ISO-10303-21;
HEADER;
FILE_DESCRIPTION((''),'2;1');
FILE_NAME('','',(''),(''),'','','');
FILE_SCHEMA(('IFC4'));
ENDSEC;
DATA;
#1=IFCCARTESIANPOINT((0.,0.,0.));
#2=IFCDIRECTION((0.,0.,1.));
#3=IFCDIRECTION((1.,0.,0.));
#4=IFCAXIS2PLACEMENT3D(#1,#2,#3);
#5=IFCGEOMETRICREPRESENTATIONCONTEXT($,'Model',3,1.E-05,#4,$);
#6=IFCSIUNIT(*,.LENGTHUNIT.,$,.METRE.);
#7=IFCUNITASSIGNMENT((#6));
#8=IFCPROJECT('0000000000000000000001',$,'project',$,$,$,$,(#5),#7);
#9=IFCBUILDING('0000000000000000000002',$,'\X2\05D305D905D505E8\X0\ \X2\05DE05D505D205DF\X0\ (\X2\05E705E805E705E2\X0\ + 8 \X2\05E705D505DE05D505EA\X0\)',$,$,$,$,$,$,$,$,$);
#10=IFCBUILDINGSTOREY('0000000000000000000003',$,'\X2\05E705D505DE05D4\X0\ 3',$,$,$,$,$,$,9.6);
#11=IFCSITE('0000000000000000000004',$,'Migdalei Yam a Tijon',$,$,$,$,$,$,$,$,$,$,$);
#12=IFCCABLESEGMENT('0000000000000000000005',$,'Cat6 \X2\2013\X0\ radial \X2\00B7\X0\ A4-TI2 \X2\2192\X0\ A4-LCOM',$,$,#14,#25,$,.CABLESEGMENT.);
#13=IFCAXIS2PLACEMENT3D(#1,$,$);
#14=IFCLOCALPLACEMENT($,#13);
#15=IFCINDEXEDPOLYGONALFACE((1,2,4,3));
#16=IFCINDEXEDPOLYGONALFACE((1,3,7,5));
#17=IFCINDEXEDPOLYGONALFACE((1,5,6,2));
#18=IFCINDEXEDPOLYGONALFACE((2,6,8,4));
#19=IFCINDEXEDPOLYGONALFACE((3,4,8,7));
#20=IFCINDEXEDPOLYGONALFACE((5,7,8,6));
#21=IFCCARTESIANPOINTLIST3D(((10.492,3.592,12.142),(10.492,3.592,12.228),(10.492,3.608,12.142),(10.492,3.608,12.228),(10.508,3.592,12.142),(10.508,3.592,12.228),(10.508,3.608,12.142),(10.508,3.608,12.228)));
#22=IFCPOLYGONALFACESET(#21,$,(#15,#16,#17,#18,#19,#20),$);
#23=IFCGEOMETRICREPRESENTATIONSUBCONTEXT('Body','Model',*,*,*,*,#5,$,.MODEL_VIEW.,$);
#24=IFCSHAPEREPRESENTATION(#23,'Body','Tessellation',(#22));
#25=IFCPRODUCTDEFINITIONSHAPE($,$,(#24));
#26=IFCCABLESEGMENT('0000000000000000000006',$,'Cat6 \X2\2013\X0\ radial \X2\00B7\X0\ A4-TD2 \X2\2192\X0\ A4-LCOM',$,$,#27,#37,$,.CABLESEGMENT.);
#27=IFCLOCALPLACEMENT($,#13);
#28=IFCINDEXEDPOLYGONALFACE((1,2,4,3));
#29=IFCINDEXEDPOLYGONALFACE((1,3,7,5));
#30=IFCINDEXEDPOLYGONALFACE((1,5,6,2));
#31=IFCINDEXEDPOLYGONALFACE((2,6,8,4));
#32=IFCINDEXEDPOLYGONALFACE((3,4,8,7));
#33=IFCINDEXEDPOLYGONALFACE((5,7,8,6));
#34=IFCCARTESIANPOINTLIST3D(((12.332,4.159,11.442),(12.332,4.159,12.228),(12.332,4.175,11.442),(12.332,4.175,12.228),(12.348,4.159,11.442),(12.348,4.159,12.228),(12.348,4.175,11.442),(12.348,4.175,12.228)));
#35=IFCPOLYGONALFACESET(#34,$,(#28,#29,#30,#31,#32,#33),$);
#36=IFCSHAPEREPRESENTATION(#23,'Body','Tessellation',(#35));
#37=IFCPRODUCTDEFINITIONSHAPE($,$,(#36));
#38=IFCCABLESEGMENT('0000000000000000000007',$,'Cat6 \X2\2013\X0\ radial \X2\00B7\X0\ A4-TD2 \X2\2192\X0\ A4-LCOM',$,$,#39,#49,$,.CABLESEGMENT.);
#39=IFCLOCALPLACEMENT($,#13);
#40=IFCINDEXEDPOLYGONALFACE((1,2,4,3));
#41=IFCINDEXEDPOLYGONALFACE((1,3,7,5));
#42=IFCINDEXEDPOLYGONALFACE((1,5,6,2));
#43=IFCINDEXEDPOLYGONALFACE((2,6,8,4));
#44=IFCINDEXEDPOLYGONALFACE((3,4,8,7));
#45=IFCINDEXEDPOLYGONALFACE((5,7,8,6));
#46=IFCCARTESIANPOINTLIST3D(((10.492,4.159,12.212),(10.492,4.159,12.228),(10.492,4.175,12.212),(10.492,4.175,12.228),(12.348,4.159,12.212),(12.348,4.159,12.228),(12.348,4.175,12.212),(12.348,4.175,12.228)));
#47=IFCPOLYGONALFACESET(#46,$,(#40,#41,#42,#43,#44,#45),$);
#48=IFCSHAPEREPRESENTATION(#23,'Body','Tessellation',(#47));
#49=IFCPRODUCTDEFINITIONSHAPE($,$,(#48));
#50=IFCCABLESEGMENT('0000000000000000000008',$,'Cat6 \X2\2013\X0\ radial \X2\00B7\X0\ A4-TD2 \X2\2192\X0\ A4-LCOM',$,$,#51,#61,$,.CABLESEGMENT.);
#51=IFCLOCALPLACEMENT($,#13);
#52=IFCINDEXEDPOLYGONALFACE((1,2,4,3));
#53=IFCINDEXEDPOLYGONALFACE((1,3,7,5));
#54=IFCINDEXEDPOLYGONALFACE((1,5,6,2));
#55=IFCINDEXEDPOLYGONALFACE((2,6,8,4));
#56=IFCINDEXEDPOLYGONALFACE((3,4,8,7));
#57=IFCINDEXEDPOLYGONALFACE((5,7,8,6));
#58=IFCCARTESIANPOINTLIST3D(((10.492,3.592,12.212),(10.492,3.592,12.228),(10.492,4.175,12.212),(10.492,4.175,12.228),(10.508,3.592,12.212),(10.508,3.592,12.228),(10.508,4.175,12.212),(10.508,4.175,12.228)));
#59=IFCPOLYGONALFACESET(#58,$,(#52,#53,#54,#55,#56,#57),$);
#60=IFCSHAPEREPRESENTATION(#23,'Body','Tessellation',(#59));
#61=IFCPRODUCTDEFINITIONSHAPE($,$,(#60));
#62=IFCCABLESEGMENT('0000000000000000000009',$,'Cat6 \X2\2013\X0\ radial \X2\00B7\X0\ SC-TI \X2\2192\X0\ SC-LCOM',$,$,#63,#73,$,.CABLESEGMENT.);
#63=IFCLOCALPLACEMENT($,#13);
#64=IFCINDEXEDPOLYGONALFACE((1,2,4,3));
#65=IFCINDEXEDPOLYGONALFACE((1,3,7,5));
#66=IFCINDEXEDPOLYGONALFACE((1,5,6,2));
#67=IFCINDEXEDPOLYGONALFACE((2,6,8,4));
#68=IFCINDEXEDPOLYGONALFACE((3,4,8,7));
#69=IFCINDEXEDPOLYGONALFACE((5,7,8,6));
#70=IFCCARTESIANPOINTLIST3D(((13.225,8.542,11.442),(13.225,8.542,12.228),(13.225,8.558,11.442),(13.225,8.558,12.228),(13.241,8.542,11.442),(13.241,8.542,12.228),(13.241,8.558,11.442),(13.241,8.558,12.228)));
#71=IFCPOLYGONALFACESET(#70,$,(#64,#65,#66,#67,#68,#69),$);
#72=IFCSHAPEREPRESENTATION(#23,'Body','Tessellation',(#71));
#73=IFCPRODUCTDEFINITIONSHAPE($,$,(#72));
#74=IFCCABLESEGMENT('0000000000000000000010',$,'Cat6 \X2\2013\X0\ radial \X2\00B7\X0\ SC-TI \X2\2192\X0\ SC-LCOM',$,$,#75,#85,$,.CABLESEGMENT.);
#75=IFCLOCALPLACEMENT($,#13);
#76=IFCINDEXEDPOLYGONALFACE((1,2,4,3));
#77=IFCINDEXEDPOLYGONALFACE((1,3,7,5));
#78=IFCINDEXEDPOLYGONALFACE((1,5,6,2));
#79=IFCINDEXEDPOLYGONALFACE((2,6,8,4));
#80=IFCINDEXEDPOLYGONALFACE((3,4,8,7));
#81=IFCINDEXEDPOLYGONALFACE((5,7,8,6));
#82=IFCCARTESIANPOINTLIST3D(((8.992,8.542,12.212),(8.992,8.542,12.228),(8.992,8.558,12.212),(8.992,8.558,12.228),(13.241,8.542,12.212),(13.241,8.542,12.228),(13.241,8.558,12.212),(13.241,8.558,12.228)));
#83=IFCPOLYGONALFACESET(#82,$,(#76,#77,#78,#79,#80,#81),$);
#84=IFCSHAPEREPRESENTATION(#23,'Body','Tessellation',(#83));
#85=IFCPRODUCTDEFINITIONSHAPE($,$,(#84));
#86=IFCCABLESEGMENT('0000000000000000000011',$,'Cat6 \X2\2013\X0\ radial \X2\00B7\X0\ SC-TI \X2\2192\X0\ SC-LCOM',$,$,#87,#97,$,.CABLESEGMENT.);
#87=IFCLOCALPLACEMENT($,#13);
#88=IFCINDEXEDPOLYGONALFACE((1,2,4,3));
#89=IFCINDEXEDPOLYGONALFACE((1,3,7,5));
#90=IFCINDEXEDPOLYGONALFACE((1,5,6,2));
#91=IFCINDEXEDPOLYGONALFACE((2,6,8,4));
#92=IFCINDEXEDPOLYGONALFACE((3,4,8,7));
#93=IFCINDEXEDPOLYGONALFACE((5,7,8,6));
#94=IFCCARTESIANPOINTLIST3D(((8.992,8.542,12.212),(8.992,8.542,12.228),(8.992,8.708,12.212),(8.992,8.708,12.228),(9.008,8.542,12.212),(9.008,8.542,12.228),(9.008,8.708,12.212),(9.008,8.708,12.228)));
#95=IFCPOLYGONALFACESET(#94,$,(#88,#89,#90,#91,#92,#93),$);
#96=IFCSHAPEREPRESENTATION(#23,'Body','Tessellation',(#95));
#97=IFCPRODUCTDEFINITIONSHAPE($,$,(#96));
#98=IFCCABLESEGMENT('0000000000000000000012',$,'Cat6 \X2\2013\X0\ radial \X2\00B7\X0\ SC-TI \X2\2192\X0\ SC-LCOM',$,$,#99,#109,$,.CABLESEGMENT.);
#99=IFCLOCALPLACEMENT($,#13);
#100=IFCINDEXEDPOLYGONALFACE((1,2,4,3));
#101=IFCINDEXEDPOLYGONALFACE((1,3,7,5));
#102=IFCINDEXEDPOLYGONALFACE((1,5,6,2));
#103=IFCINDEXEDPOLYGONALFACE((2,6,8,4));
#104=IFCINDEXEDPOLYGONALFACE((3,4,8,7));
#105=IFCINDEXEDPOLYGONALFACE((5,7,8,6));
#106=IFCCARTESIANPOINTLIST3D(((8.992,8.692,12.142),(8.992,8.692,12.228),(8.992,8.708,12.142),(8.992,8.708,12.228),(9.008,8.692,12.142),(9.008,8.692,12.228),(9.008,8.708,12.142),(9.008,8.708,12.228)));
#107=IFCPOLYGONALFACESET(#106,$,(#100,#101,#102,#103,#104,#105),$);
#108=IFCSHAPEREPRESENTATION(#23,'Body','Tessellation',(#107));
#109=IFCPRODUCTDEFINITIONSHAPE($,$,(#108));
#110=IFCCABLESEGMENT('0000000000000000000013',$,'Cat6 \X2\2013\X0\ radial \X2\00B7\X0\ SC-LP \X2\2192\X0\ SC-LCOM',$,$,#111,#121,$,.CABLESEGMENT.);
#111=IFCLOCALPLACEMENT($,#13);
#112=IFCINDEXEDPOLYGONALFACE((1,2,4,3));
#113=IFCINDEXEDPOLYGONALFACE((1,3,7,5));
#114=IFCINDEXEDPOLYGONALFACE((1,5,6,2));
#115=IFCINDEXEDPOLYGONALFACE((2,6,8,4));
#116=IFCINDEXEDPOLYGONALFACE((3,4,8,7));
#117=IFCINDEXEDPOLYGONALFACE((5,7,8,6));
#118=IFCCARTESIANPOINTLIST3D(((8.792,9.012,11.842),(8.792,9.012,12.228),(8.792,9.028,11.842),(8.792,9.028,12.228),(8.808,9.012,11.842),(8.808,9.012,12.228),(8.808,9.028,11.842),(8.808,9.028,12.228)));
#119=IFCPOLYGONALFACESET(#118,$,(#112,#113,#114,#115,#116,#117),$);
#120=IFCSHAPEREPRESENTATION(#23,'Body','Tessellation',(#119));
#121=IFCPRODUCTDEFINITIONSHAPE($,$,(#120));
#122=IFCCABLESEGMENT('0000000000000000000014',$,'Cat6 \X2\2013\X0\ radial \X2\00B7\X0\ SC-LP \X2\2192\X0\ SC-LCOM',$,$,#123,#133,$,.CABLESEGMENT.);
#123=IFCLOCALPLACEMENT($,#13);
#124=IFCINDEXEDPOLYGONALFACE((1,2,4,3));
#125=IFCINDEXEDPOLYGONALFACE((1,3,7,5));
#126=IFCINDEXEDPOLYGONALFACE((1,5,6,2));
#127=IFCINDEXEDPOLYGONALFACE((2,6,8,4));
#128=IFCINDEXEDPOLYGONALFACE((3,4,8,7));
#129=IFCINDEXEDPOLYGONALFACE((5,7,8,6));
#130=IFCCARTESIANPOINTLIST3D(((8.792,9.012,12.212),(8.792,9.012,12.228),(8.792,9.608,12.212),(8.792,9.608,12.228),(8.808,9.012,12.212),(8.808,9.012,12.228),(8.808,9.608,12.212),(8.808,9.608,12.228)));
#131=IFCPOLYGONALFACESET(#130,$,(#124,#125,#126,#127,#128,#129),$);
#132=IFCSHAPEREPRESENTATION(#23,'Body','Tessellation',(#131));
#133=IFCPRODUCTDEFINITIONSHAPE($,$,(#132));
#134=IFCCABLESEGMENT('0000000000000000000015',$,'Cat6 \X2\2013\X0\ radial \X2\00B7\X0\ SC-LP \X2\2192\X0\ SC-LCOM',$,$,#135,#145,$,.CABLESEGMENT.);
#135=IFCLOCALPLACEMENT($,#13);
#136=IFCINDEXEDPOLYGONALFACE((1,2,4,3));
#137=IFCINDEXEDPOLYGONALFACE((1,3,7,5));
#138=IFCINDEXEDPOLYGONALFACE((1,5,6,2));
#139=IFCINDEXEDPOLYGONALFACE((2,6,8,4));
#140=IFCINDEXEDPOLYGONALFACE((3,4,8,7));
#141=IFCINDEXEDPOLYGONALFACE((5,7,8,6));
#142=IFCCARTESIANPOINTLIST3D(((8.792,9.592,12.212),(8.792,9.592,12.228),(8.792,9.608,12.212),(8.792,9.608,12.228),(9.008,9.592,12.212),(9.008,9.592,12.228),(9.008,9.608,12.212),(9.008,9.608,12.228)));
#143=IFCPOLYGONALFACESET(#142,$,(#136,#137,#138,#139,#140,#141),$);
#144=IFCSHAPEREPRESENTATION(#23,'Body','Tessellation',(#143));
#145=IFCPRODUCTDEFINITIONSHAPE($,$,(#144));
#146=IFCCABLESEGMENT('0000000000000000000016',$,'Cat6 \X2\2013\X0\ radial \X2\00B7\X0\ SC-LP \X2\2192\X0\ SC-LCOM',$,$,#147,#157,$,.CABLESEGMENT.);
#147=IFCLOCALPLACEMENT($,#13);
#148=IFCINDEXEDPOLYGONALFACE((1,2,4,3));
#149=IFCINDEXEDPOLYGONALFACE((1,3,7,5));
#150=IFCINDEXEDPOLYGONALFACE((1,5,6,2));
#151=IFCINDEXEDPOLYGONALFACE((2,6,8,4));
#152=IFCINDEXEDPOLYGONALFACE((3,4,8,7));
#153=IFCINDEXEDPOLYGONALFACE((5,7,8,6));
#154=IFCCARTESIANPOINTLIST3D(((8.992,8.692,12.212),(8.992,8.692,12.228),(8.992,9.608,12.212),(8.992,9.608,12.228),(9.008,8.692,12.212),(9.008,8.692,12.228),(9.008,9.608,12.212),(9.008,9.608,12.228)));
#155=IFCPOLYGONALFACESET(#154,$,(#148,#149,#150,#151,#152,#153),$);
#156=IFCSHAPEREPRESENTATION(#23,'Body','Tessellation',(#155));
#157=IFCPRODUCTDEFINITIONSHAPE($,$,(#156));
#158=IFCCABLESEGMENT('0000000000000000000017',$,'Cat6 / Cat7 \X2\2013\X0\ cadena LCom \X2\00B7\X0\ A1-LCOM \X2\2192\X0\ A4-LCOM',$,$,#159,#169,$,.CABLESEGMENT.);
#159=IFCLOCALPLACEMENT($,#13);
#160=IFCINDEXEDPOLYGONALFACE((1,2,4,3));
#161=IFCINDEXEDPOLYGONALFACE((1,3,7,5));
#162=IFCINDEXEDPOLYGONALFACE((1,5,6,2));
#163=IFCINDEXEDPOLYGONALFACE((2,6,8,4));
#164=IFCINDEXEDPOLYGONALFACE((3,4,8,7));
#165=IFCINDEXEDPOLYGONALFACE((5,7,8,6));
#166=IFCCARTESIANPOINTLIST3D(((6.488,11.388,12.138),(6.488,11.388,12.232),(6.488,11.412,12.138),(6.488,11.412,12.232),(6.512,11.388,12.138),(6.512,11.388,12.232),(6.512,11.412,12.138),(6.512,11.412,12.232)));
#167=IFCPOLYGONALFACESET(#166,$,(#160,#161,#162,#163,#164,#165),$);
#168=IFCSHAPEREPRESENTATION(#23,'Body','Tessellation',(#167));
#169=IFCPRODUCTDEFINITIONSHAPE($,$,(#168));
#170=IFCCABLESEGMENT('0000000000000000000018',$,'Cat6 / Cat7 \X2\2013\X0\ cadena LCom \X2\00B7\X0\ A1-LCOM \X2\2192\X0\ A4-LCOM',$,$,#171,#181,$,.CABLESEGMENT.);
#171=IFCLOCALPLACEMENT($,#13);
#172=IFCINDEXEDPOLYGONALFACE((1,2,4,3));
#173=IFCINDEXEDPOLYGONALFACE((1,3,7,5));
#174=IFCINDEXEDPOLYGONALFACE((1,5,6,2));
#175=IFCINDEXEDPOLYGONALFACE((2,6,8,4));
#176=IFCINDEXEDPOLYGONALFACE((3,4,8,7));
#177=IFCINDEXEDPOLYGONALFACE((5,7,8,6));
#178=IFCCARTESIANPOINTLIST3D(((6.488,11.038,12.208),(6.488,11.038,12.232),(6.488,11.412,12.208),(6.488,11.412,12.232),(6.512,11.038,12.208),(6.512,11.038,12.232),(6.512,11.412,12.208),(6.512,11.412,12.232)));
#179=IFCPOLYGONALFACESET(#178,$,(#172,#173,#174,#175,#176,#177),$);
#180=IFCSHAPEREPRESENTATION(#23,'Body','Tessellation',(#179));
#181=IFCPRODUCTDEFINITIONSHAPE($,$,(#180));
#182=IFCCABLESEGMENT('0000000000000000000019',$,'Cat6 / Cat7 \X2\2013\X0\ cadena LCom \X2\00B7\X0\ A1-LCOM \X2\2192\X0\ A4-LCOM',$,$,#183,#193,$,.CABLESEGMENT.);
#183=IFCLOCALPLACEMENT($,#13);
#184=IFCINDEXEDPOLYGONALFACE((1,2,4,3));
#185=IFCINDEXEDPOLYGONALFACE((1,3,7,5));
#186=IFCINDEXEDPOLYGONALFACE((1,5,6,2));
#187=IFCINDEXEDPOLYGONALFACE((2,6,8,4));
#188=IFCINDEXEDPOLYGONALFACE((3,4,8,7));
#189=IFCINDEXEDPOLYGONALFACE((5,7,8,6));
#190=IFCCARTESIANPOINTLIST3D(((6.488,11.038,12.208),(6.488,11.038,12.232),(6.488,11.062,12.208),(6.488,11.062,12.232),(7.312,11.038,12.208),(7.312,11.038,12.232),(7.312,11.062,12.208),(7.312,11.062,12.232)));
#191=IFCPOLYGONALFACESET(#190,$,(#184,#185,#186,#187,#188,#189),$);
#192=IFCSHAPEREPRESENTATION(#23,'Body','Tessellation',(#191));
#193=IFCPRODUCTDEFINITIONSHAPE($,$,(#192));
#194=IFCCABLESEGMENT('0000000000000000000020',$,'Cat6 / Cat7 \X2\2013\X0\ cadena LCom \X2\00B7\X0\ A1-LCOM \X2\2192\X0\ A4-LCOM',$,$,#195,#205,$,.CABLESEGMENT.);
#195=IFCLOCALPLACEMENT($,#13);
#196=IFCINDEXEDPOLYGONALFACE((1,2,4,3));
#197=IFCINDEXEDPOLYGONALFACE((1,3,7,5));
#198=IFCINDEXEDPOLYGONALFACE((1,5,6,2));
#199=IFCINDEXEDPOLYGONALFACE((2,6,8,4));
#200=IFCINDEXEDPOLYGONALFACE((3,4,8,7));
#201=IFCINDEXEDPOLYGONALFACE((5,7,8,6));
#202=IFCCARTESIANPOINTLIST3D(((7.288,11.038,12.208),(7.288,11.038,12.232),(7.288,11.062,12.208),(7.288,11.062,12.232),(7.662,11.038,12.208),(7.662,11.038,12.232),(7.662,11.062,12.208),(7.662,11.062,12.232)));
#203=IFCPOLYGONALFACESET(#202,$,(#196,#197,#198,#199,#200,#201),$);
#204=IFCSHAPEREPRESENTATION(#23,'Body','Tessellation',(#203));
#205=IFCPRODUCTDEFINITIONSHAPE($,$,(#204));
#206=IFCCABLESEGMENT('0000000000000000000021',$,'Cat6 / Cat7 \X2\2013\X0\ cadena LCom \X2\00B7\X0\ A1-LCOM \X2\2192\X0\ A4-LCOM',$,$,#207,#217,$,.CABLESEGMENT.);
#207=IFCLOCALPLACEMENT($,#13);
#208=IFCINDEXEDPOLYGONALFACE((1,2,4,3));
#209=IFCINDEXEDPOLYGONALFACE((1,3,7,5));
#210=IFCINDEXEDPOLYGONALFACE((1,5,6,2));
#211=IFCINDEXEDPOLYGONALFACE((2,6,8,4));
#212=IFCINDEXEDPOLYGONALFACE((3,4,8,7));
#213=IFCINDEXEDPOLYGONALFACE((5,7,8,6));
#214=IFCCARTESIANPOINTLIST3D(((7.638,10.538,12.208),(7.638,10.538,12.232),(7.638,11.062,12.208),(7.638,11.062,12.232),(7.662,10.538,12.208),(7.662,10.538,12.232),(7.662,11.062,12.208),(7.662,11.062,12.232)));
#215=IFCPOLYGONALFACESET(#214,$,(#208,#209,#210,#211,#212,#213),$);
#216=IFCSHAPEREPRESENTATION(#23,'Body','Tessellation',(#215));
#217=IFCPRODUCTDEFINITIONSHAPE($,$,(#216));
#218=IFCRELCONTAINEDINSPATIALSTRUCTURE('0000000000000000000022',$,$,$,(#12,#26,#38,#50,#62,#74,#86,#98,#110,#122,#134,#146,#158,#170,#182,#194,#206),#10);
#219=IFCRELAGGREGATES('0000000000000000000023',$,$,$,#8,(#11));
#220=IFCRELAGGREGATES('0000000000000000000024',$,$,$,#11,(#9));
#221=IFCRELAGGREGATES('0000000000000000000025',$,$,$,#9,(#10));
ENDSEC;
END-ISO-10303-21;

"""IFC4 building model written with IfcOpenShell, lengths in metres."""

from ifc_helpers import new_model, si_unit, frame, origin_with_axes, context, subcontext, project, spatial, line, indexed_curve, outline, extrude, element, save


model = new_model("IFC4")

# Units and contexts
model_context = context("Model", 3, precision=1e-05, world=origin_with_axes())
body_context = subcontext(model_context, "Body", "Model", "MODEL_VIEW")
ifc_project = project(units=[si_unit("LENGTHUNIT", "METRE")], contexts=[model_context])

# Site, building, storey
site = spatial("IfcSite", under=ifc_project, Name="Migdalei Yam a Tijon")
building = spatial("IfcBuilding", under=site, Name="דיור מוגן (קרקע + 8 קומות)")
storey = spatial("IfcBuildingStorey", under=building, Name="קומה 3", Elevation=9.6)

# Cable segments
element("IfcCableSegment", 1, inside=storey, Name="Cat6 – radial · A4-TI2 → A4-LCOM", PredefinedType="CABLESEGMENT", context=body_context, shape_type="SweptSolid", body=[
    extrude(outline(indexed_curve([(0.0, 0.0), (0.016, 0.0), (0.016, 0.016), (0.0, 0.016)], segments=[line(1, 2, 3, 4, 1)])), frame((10.492, 3.592, 12.142), z_axis=(0.0, 0.0, 1.0), x_axis=(1.0, 0.0, 0.0)), (0.0, 0.0, 1.0), 0.086),
])
element("IfcCableSegment", 2, inside=storey, Name="Cat6 – radial · A4-TD2 → A4-LCOM", PredefinedType="CABLESEGMENT", context=body_context, shape_type="SweptSolid", body=[
    extrude(outline(indexed_curve([(0.0, 0.0), (0.016, 0.0), (0.016, 0.016), (0.0, 0.016)], segments=[line(1, 2, 3, 4, 1)])), frame((12.332, 4.159, 11.442), z_axis=(0.0, 0.0, 1.0), x_axis=(1.0, 0.0, 0.0)), (0.0, 0.0, 1.0), 0.786),
])
element("IfcCableSegment", 3, inside=storey, Name="Cat6 – radial · A4-TD2 → A4-LCOM", PredefinedType="CABLESEGMENT", context=body_context, shape_type="SweptSolid", body=[
    extrude(outline(indexed_curve([(0.0, 0.0), (1.856, 0.0), (1.856, 0.016), (0.0, 0.016)], segments=[line(1, 2, 3, 4, 1)])), frame((10.492, 4.159, 12.212), z_axis=(0.0, 0.0, 1.0), x_axis=(1.0, 0.0, 0.0)), (0.0, 0.0, 1.0), 0.016),
])
element("IfcCableSegment", 4, inside=storey, Name="Cat6 – radial · A4-TD2 → A4-LCOM", PredefinedType="CABLESEGMENT", context=body_context, shape_type="SweptSolid", body=[
    extrude(outline(indexed_curve([(0.0, 0.0), (0.016, 0.0), (0.016, 0.583), (0.0, 0.583)], segments=[line(1, 2, 3, 4, 1)])), frame((10.492, 3.592, 12.212), z_axis=(0.0, 0.0, 1.0), x_axis=(1.0, 0.0, 0.0)), (0.0, 0.0, 1.0), 0.016),
])
element("IfcCableSegment", 5, inside=storey, Name="Cat6 – radial · SC-TI → SC-LCOM", PredefinedType="CABLESEGMENT", context=body_context, shape_type="SweptSolid", body=[
    extrude(outline(indexed_curve([(0.0, 0.0), (0.016, 0.0), (0.016, 0.016), (0.0, 0.016)], segments=[line(1, 2, 3, 4, 1)])), frame((13.225, 8.542, 11.442), z_axis=(0.0, 0.0, 1.0), x_axis=(1.0, 0.0, 0.0)), (0.0, 0.0, 1.0), 0.786),
])
element("IfcCableSegment", 6, inside=storey, Name="Cat6 – radial · SC-TI → SC-LCOM", PredefinedType="CABLESEGMENT", context=body_context, shape_type="SweptSolid", body=[
    extrude(outline(indexed_curve([(0.0, 0.0), (4.249, 0.0), (4.249, 0.016), (0.0, 0.016)], segments=[line(1, 2, 3, 4, 1)])), frame((8.992, 8.542, 12.212), z_axis=(0.0, 0.0, 1.0), x_axis=(1.0, 0.0, 0.0)), (0.0, 0.0, 1.0), 0.016),
])
element("IfcCableSegment", 7, inside=storey, Name="Cat6 – radial · SC-TI → SC-LCOM", PredefinedType="CABLESEGMENT", context=body_context, shape_type="SweptSolid", body=[
    extrude(outline(indexed_curve([(0.0, 0.0), (0.016, 0.0), (0.016, 0.166), (0.0, 0.166)], segments=[line(1, 2, 3, 4, 1)])), frame((8.992, 8.542, 12.212), z_axis=(0.0, 0.0, 1.0), x_axis=(1.0, 0.0, 0.0)), (0.0, 0.0, 1.0), 0.016),
])
element("IfcCableSegment", 8, inside=storey, Name="Cat6 – radial · SC-TI → SC-LCOM", PredefinedType="CABLESEGMENT", context=body_context, shape_type="SweptSolid", body=[
    extrude(outline(indexed_curve([(0.0, 0.0), (0.016, 0.0), (0.016, 0.016), (0.0, 0.016)], segments=[line(1, 2, 3, 4, 1)])), frame((8.992, 8.692, 12.142), z_axis=(0.0, 0.0, 1.0), x_axis=(1.0, 0.0, 0.0)), (0.0, 0.0, 1.0), 0.086),
])
element("IfcCableSegment", 9, inside=storey, Name="Cat6 – radial · SC-LP → SC-LCOM", PredefinedType="CABLESEGMENT", context=body_context, shape_type="SweptSolid", body=[
    extrude(outline(indexed_curve([(0.0, 0.0), (0.016, 0.0), (0.016, 0.016), (0.0, 0.016)], segments=[line(1, 2, 3, 4, 1)])), frame((8.792, 9.012, 11.842), z_axis=(0.0, 0.0, 1.0), x_axis=(1.0, 0.0, 0.0)), (0.0, 0.0, 1.0), 0.386),
])
element("IfcCableSegment", 10, inside=storey, Name="Cat6 – radial · SC-LP → SC-LCOM", PredefinedType="CABLESEGMENT", context=body_context, shape_type="SweptSolid", body=[
    extrude(outline(indexed_curve([(0.0, 0.0), (0.016, 0.0), (0.016, 0.596), (0.0, 0.596)], segments=[line(1, 2, 3, 4, 1)])), frame((8.792, 9.012, 12.212), z_axis=(0.0, 0.0, 1.0), x_axis=(1.0, 0.0, 0.0)), (0.0, 0.0, 1.0), 0.016),
])
element("IfcCableSegment", 11, inside=storey, Name="Cat6 – radial · SC-LP → SC-LCOM", PredefinedType="CABLESEGMENT", context=body_context, shape_type="SweptSolid", body=[
    extrude(outline(indexed_curve([(0.0, 0.0), (0.216, 0.0), (0.216, 0.016), (0.0, 0.016)], segments=[line(1, 2, 3, 4, 1)])), frame((8.792, 9.592, 12.212), z_axis=(0.0, 0.0, 1.0), x_axis=(1.0, 0.0, 0.0)), (0.0, 0.0, 1.0), 0.016),
])
element("IfcCableSegment", 12, inside=storey, Name="Cat6 – radial · SC-LP → SC-LCOM", PredefinedType="CABLESEGMENT", context=body_context, shape_type="SweptSolid", body=[
    extrude(outline(indexed_curve([(0.0, 0.0), (0.016, 0.0), (0.016, 0.916), (0.0, 0.916)], segments=[line(1, 2, 3, 4, 1)])), frame((8.992, 8.692, 12.212), z_axis=(0.0, 0.0, 1.0), x_axis=(1.0, 0.0, 0.0)), (0.0, 0.0, 1.0), 0.016),
])
element("IfcCableSegment", 13, inside=storey, Name="Cat6 / Cat7 – cadena LCom · A1-LCOM → A4-LCOM", PredefinedType="CABLESEGMENT", context=body_context, shape_type="SweptSolid", body=[
    extrude(outline(indexed_curve([(0.0, 0.0), (0.024, 0.0), (0.024, 0.024), (0.0, 0.024)], segments=[line(1, 2, 3, 4, 1)])), frame((6.488, 11.388, 12.138), z_axis=(0.0, 0.0, 1.0), x_axis=(1.0, 0.0, 0.0)), (0.0, 0.0, 1.0), 0.094),
])
element("IfcCableSegment", 14, inside=storey, Name="Cat6 / Cat7 – cadena LCom · A1-LCOM → A4-LCOM", PredefinedType="CABLESEGMENT", context=body_context, shape_type="SweptSolid", body=[
    extrude(outline(indexed_curve([(0.0, 0.0), (0.024, 0.0), (0.024, 0.374), (0.0, 0.374)], segments=[line(1, 2, 3, 4, 1)])), frame((6.488, 11.038, 12.208), z_axis=(0.0, 0.0, 1.0), x_axis=(1.0, 0.0, 0.0)), (0.0, 0.0, 1.0), 0.024),
])
element("IfcCableSegment", 15, inside=storey, Name="Cat6 / Cat7 – cadena LCom · A1-LCOM → A4-LCOM", PredefinedType="CABLESEGMENT", context=body_context, shape_type="SweptSolid", body=[
    extrude(outline(indexed_curve([(0.0, 0.0), (0.824, 0.0), (0.824, 0.024), (0.0, 0.024)], segments=[line(1, 2, 3, 4, 1)])), frame((6.488, 11.038, 12.208), z_axis=(0.0, 0.0, 1.0), x_axis=(1.0, 0.0, 0.0)), (0.0, 0.0, 1.0), 0.024),
])
element("IfcCableSegment", 16, inside=storey, Name="Cat6 / Cat7 – cadena LCom · A1-LCOM → A4-LCOM", PredefinedType="CABLESEGMENT", context=body_context, shape_type="SweptSolid", body=[
    extrude(outline(indexed_curve([(0.0, 0.0), (0.374, 0.0), (0.374, 0.024), (0.0, 0.024)], segments=[line(1, 2, 3, 4, 1)])), frame((7.288, 11.038, 12.208), z_axis=(0.0, 0.0, 1.0), x_axis=(1.0, 0.0, 0.0)), (0.0, 0.0, 1.0), 0.024),
])
element("IfcCableSegment", 17, inside=storey, Name="Cat6 / Cat7 – cadena LCom · A1-LCOM → A4-LCOM", PredefinedType="CABLESEGMENT", context=body_context, shape_type="SweptSolid", body=[
    extrude(outline(indexed_curve([(0.0, 0.0), (0.024, 0.0), (0.024, 0.524), (0.0, 0.524)], segments=[line(1, 2, 3, 4, 1)])), frame((7.638, 10.538, 12.208), z_axis=(0.0, 0.0, 1.0), x_axis=(1.0, 0.0, 0.0)), (0.0, 0.0, 1.0), 0.024),
])

save(model, "model.ifc")
